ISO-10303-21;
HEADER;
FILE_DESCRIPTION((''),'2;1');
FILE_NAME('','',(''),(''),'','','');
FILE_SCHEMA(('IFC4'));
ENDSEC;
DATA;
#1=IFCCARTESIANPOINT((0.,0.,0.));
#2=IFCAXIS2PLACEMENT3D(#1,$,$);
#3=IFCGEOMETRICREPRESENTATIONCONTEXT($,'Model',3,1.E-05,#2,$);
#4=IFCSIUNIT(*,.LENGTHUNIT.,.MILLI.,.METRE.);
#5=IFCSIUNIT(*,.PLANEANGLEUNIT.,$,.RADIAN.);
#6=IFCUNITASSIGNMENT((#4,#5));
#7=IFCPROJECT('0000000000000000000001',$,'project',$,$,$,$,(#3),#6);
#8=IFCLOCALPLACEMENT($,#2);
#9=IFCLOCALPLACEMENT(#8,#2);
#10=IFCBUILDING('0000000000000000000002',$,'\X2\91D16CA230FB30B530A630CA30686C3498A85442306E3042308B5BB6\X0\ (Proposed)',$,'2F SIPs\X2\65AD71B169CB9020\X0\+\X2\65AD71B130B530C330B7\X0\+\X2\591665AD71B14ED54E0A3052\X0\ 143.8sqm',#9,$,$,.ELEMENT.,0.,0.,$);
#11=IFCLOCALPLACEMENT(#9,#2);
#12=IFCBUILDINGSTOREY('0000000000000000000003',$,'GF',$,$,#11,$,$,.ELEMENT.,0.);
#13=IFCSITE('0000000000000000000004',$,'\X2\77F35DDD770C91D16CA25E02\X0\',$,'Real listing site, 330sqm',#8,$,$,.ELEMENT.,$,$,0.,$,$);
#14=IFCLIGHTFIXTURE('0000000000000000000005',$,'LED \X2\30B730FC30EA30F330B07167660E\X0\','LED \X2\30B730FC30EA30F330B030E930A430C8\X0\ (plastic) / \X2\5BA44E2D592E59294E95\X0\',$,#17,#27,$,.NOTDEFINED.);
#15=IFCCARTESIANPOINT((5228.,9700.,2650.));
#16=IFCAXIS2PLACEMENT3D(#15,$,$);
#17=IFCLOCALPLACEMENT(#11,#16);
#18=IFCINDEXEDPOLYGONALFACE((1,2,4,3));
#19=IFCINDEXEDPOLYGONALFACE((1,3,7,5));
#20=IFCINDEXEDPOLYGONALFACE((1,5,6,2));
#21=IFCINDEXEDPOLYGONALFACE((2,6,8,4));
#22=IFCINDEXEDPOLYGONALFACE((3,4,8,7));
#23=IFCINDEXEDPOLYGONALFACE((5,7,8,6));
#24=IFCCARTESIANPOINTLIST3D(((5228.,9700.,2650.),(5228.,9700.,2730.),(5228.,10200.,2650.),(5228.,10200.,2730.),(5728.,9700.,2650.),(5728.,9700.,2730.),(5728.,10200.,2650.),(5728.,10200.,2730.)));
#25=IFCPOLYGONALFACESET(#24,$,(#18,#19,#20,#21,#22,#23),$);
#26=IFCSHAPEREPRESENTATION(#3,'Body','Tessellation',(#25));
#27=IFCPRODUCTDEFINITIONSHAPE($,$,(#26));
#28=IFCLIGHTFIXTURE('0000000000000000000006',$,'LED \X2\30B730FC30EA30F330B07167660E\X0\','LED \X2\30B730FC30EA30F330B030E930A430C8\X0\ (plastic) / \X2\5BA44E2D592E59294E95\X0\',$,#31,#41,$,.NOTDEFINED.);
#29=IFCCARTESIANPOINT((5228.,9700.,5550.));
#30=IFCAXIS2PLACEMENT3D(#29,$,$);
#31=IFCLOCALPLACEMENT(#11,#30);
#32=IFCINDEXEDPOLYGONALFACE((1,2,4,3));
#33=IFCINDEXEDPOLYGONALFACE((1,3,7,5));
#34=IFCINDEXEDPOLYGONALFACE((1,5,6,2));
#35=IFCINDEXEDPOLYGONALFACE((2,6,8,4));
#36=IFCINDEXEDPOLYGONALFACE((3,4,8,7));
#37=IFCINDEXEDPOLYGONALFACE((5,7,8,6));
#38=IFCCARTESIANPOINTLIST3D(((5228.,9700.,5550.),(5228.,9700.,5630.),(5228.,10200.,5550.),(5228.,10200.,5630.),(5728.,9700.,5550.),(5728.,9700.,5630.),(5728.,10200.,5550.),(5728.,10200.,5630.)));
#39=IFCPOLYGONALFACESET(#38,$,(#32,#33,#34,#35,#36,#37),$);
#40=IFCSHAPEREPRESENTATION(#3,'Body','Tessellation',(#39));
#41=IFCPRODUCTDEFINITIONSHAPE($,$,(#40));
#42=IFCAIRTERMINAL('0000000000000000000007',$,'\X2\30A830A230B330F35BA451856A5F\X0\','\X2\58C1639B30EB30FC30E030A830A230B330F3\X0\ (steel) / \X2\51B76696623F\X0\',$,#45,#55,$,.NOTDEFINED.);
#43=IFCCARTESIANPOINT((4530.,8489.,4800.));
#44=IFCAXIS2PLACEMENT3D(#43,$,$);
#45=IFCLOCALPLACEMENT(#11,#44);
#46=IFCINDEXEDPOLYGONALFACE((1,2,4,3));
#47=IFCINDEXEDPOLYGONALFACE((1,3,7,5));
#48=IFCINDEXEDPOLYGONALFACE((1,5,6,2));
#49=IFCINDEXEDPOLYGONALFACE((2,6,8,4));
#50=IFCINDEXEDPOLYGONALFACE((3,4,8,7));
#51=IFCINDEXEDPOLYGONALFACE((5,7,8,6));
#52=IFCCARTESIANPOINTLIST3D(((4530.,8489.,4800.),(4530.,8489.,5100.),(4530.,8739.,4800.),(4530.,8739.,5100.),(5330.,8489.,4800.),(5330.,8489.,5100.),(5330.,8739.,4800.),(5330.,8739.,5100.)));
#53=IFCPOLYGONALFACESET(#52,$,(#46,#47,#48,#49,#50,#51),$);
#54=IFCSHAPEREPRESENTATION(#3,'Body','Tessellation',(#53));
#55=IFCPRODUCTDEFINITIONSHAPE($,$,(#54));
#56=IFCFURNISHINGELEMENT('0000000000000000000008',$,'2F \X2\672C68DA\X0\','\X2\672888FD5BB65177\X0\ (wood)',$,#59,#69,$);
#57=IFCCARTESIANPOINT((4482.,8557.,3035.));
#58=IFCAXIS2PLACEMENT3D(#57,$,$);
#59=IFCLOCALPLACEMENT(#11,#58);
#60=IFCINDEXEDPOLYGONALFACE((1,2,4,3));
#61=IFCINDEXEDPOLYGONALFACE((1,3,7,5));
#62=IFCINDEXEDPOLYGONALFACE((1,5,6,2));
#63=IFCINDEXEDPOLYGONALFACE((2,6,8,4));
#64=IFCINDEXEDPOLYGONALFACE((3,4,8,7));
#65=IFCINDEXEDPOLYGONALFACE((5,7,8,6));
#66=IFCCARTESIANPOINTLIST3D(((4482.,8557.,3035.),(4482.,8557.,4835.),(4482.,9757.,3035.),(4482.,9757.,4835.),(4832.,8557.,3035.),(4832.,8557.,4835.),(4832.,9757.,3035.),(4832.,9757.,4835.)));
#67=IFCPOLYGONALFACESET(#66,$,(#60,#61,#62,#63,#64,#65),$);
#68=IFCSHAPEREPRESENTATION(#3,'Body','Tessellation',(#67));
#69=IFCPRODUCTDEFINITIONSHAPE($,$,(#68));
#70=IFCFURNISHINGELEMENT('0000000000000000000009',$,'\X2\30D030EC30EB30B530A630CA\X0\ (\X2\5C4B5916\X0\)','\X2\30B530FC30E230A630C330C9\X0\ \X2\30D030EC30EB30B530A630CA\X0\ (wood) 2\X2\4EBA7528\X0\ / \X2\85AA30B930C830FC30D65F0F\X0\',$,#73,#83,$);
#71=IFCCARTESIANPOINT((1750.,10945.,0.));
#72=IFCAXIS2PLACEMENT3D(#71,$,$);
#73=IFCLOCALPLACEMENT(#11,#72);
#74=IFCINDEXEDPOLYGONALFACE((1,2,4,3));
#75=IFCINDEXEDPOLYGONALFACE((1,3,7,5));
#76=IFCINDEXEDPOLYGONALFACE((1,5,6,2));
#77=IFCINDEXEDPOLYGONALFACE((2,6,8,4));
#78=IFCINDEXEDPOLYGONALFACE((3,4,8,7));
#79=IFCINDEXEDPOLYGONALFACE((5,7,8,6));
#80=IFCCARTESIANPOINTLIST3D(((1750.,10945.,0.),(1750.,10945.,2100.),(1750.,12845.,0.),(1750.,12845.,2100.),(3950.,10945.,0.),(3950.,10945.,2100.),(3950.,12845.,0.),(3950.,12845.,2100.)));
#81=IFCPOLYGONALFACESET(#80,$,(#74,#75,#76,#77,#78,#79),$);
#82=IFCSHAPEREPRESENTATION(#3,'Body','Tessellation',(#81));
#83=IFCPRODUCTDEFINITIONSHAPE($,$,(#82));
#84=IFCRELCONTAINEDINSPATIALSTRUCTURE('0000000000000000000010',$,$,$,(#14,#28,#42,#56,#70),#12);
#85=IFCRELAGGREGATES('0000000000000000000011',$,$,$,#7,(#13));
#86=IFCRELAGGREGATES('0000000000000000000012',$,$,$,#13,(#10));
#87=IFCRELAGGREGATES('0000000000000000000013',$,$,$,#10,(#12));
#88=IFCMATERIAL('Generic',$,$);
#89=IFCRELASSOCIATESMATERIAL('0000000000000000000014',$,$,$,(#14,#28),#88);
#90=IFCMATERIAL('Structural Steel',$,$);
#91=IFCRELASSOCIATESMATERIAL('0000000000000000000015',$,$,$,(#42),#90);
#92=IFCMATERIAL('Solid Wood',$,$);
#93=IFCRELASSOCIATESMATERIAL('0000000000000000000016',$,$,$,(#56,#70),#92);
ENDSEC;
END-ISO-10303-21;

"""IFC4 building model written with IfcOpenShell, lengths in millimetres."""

from ifc_helpers import new_model, si_unit, frame, frame_2d, origin, place, context, project, spatial, rectangle, extrude, material, element, save


model = new_model("IFC4")

# Units and contexts
model_context = context("Model", 3, precision=1e-05, world=origin())
ifc_project = project(units=[si_unit("LENGTHUNIT", "METRE", prefix="MILLI"), si_unit("PLANEANGLEUNIT", "RADIAN")], contexts=[model_context])

# Site, building, storey
site_placement = place(None, origin())
site = spatial("IfcSite", under=ifc_project, at=site_placement, Name="石川県金沢市", ObjectType="Real listing site, 330sqm", CompositionType="ELEMENT", RefElevation=0.0)
building_placement = place(site_placement, origin())
building = spatial("IfcBuilding", under=site, at=building_placement, Name="金沢・サウナと水風呂のある家 (Proposed)", ObjectType="2F SIPs断熱構造+断熱サッシ+外断熱仕上げ 143.8sqm", CompositionType="ELEMENT", ElevationOfRefHeight=0.0, ElevationOfTerrain=0.0)
storey_placement = place(building_placement, origin())
storey = spatial("IfcBuildingStorey", under=building, at=storey_placement, Name="GF", CompositionType="ELEMENT", Elevation=0.0)

# Shared definitions
ifc_material_1 = material(Name="Solid Wood")

# Shared definitions
ifc_material_2 = material(Name="Structural Steel")

# Shared definitions
ifc_material_3 = material(Name="Generic")

# Light fixtures
light_fixture_1_placement = place(storey_placement, frame((5228.0, 9700.0, 2650.0)))
element("IfcLightFixture", 1, at=light_fixture_1_placement, inside=storey, material=ifc_material_3, Name="LED シーリング照明", Description="LED シーリングライト (plastic) / 室中央天井", PredefinedType="NOTDEFINED", context=model_context, shape_type="SweptSolid", body=[
    extrude(rectangle(XDim=500.0, YDim=500.0, at=frame_2d((250.0, 250.0))), frame((5228.0, 9700.0, 2650.0)), (0.0, 0.0, 1.0), 80.0),
])
light_fixture_2_placement = place(storey_placement, frame((5228.0, 9700.0, 5550.0)))
element("IfcLightFixture", 2, at=light_fixture_2_placement, inside=storey, material=ifc_material_3, Name="LED シーリング照明", Description="LED シーリングライト (plastic) / 室中央天井", PredefinedType="NOTDEFINED", context=model_context, shape_type="SweptSolid", body=[
    extrude(rectangle(XDim=500.0, YDim=500.0, at=frame_2d((250.0, 250.0))), frame((5228.0, 9700.0, 5550.0)), (0.0, 0.0, 1.0), 80.0),
])

# Air terminal
air_terminal_placement = place(storey_placement, frame((4530.0, 8489.0, 4800.0)))
element("IfcAirTerminal", 3, at=air_terminal_placement, inside=storey, material=ifc_material_2, Name="エアコン室内機", Description="壁掛ルームエアコン (steel) / 冷暖房", PredefinedType="NOTDEFINED", context=model_context, shape_type="SweptSolid", body=[
    extrude(rectangle(XDim=800.0, YDim=250.0, at=frame_2d((400.0, 125.0))), frame((4530.0, 8489.0, 4800.0)), (0.0, 0.0, 1.0), 300.0),
])

# Furnishing elements
furnishing_1_placement = place(storey_placement, frame((4482.0, 8557.0, 3035.0)))
element("IfcFurnishingElement", 4, at=furnishing_1_placement, inside=storey, material=ifc_material_1, Name="2F 本棚", Description="木製家具 (wood)", context=model_context, shape_type="SweptSolid", body=[
    extrude(rectangle(XDim=350.0, YDim=1200.0, at=frame_2d((175.0, 600.0))), frame((4482.0, 8557.0, 3035.0)), (0.0, 0.0, 1.0), 1800.0),
])
furnishing_2_placement = place(storey_placement, frame((1750.0, 10945.0, 0.0)))
element("IfcFurnishingElement", 5, at=furnishing_2_placement, inside=storey, material=ifc_material_1, Name="バレルサウナ (屋外)", Description="サーモウッド バレルサウナ (wood) 2人用 / 薪ストーブ式", context=model_context, shape_type="SweptSolid", body=[
    extrude(rectangle(XDim=2200.0, YDim=1900.0, at=frame_2d((1100.0, 950.0))), frame((1750.0, 10945.0, 0.0)), (0.0, 0.0, 1.0), 2100.0),
])

save(model, "model.ifc")
